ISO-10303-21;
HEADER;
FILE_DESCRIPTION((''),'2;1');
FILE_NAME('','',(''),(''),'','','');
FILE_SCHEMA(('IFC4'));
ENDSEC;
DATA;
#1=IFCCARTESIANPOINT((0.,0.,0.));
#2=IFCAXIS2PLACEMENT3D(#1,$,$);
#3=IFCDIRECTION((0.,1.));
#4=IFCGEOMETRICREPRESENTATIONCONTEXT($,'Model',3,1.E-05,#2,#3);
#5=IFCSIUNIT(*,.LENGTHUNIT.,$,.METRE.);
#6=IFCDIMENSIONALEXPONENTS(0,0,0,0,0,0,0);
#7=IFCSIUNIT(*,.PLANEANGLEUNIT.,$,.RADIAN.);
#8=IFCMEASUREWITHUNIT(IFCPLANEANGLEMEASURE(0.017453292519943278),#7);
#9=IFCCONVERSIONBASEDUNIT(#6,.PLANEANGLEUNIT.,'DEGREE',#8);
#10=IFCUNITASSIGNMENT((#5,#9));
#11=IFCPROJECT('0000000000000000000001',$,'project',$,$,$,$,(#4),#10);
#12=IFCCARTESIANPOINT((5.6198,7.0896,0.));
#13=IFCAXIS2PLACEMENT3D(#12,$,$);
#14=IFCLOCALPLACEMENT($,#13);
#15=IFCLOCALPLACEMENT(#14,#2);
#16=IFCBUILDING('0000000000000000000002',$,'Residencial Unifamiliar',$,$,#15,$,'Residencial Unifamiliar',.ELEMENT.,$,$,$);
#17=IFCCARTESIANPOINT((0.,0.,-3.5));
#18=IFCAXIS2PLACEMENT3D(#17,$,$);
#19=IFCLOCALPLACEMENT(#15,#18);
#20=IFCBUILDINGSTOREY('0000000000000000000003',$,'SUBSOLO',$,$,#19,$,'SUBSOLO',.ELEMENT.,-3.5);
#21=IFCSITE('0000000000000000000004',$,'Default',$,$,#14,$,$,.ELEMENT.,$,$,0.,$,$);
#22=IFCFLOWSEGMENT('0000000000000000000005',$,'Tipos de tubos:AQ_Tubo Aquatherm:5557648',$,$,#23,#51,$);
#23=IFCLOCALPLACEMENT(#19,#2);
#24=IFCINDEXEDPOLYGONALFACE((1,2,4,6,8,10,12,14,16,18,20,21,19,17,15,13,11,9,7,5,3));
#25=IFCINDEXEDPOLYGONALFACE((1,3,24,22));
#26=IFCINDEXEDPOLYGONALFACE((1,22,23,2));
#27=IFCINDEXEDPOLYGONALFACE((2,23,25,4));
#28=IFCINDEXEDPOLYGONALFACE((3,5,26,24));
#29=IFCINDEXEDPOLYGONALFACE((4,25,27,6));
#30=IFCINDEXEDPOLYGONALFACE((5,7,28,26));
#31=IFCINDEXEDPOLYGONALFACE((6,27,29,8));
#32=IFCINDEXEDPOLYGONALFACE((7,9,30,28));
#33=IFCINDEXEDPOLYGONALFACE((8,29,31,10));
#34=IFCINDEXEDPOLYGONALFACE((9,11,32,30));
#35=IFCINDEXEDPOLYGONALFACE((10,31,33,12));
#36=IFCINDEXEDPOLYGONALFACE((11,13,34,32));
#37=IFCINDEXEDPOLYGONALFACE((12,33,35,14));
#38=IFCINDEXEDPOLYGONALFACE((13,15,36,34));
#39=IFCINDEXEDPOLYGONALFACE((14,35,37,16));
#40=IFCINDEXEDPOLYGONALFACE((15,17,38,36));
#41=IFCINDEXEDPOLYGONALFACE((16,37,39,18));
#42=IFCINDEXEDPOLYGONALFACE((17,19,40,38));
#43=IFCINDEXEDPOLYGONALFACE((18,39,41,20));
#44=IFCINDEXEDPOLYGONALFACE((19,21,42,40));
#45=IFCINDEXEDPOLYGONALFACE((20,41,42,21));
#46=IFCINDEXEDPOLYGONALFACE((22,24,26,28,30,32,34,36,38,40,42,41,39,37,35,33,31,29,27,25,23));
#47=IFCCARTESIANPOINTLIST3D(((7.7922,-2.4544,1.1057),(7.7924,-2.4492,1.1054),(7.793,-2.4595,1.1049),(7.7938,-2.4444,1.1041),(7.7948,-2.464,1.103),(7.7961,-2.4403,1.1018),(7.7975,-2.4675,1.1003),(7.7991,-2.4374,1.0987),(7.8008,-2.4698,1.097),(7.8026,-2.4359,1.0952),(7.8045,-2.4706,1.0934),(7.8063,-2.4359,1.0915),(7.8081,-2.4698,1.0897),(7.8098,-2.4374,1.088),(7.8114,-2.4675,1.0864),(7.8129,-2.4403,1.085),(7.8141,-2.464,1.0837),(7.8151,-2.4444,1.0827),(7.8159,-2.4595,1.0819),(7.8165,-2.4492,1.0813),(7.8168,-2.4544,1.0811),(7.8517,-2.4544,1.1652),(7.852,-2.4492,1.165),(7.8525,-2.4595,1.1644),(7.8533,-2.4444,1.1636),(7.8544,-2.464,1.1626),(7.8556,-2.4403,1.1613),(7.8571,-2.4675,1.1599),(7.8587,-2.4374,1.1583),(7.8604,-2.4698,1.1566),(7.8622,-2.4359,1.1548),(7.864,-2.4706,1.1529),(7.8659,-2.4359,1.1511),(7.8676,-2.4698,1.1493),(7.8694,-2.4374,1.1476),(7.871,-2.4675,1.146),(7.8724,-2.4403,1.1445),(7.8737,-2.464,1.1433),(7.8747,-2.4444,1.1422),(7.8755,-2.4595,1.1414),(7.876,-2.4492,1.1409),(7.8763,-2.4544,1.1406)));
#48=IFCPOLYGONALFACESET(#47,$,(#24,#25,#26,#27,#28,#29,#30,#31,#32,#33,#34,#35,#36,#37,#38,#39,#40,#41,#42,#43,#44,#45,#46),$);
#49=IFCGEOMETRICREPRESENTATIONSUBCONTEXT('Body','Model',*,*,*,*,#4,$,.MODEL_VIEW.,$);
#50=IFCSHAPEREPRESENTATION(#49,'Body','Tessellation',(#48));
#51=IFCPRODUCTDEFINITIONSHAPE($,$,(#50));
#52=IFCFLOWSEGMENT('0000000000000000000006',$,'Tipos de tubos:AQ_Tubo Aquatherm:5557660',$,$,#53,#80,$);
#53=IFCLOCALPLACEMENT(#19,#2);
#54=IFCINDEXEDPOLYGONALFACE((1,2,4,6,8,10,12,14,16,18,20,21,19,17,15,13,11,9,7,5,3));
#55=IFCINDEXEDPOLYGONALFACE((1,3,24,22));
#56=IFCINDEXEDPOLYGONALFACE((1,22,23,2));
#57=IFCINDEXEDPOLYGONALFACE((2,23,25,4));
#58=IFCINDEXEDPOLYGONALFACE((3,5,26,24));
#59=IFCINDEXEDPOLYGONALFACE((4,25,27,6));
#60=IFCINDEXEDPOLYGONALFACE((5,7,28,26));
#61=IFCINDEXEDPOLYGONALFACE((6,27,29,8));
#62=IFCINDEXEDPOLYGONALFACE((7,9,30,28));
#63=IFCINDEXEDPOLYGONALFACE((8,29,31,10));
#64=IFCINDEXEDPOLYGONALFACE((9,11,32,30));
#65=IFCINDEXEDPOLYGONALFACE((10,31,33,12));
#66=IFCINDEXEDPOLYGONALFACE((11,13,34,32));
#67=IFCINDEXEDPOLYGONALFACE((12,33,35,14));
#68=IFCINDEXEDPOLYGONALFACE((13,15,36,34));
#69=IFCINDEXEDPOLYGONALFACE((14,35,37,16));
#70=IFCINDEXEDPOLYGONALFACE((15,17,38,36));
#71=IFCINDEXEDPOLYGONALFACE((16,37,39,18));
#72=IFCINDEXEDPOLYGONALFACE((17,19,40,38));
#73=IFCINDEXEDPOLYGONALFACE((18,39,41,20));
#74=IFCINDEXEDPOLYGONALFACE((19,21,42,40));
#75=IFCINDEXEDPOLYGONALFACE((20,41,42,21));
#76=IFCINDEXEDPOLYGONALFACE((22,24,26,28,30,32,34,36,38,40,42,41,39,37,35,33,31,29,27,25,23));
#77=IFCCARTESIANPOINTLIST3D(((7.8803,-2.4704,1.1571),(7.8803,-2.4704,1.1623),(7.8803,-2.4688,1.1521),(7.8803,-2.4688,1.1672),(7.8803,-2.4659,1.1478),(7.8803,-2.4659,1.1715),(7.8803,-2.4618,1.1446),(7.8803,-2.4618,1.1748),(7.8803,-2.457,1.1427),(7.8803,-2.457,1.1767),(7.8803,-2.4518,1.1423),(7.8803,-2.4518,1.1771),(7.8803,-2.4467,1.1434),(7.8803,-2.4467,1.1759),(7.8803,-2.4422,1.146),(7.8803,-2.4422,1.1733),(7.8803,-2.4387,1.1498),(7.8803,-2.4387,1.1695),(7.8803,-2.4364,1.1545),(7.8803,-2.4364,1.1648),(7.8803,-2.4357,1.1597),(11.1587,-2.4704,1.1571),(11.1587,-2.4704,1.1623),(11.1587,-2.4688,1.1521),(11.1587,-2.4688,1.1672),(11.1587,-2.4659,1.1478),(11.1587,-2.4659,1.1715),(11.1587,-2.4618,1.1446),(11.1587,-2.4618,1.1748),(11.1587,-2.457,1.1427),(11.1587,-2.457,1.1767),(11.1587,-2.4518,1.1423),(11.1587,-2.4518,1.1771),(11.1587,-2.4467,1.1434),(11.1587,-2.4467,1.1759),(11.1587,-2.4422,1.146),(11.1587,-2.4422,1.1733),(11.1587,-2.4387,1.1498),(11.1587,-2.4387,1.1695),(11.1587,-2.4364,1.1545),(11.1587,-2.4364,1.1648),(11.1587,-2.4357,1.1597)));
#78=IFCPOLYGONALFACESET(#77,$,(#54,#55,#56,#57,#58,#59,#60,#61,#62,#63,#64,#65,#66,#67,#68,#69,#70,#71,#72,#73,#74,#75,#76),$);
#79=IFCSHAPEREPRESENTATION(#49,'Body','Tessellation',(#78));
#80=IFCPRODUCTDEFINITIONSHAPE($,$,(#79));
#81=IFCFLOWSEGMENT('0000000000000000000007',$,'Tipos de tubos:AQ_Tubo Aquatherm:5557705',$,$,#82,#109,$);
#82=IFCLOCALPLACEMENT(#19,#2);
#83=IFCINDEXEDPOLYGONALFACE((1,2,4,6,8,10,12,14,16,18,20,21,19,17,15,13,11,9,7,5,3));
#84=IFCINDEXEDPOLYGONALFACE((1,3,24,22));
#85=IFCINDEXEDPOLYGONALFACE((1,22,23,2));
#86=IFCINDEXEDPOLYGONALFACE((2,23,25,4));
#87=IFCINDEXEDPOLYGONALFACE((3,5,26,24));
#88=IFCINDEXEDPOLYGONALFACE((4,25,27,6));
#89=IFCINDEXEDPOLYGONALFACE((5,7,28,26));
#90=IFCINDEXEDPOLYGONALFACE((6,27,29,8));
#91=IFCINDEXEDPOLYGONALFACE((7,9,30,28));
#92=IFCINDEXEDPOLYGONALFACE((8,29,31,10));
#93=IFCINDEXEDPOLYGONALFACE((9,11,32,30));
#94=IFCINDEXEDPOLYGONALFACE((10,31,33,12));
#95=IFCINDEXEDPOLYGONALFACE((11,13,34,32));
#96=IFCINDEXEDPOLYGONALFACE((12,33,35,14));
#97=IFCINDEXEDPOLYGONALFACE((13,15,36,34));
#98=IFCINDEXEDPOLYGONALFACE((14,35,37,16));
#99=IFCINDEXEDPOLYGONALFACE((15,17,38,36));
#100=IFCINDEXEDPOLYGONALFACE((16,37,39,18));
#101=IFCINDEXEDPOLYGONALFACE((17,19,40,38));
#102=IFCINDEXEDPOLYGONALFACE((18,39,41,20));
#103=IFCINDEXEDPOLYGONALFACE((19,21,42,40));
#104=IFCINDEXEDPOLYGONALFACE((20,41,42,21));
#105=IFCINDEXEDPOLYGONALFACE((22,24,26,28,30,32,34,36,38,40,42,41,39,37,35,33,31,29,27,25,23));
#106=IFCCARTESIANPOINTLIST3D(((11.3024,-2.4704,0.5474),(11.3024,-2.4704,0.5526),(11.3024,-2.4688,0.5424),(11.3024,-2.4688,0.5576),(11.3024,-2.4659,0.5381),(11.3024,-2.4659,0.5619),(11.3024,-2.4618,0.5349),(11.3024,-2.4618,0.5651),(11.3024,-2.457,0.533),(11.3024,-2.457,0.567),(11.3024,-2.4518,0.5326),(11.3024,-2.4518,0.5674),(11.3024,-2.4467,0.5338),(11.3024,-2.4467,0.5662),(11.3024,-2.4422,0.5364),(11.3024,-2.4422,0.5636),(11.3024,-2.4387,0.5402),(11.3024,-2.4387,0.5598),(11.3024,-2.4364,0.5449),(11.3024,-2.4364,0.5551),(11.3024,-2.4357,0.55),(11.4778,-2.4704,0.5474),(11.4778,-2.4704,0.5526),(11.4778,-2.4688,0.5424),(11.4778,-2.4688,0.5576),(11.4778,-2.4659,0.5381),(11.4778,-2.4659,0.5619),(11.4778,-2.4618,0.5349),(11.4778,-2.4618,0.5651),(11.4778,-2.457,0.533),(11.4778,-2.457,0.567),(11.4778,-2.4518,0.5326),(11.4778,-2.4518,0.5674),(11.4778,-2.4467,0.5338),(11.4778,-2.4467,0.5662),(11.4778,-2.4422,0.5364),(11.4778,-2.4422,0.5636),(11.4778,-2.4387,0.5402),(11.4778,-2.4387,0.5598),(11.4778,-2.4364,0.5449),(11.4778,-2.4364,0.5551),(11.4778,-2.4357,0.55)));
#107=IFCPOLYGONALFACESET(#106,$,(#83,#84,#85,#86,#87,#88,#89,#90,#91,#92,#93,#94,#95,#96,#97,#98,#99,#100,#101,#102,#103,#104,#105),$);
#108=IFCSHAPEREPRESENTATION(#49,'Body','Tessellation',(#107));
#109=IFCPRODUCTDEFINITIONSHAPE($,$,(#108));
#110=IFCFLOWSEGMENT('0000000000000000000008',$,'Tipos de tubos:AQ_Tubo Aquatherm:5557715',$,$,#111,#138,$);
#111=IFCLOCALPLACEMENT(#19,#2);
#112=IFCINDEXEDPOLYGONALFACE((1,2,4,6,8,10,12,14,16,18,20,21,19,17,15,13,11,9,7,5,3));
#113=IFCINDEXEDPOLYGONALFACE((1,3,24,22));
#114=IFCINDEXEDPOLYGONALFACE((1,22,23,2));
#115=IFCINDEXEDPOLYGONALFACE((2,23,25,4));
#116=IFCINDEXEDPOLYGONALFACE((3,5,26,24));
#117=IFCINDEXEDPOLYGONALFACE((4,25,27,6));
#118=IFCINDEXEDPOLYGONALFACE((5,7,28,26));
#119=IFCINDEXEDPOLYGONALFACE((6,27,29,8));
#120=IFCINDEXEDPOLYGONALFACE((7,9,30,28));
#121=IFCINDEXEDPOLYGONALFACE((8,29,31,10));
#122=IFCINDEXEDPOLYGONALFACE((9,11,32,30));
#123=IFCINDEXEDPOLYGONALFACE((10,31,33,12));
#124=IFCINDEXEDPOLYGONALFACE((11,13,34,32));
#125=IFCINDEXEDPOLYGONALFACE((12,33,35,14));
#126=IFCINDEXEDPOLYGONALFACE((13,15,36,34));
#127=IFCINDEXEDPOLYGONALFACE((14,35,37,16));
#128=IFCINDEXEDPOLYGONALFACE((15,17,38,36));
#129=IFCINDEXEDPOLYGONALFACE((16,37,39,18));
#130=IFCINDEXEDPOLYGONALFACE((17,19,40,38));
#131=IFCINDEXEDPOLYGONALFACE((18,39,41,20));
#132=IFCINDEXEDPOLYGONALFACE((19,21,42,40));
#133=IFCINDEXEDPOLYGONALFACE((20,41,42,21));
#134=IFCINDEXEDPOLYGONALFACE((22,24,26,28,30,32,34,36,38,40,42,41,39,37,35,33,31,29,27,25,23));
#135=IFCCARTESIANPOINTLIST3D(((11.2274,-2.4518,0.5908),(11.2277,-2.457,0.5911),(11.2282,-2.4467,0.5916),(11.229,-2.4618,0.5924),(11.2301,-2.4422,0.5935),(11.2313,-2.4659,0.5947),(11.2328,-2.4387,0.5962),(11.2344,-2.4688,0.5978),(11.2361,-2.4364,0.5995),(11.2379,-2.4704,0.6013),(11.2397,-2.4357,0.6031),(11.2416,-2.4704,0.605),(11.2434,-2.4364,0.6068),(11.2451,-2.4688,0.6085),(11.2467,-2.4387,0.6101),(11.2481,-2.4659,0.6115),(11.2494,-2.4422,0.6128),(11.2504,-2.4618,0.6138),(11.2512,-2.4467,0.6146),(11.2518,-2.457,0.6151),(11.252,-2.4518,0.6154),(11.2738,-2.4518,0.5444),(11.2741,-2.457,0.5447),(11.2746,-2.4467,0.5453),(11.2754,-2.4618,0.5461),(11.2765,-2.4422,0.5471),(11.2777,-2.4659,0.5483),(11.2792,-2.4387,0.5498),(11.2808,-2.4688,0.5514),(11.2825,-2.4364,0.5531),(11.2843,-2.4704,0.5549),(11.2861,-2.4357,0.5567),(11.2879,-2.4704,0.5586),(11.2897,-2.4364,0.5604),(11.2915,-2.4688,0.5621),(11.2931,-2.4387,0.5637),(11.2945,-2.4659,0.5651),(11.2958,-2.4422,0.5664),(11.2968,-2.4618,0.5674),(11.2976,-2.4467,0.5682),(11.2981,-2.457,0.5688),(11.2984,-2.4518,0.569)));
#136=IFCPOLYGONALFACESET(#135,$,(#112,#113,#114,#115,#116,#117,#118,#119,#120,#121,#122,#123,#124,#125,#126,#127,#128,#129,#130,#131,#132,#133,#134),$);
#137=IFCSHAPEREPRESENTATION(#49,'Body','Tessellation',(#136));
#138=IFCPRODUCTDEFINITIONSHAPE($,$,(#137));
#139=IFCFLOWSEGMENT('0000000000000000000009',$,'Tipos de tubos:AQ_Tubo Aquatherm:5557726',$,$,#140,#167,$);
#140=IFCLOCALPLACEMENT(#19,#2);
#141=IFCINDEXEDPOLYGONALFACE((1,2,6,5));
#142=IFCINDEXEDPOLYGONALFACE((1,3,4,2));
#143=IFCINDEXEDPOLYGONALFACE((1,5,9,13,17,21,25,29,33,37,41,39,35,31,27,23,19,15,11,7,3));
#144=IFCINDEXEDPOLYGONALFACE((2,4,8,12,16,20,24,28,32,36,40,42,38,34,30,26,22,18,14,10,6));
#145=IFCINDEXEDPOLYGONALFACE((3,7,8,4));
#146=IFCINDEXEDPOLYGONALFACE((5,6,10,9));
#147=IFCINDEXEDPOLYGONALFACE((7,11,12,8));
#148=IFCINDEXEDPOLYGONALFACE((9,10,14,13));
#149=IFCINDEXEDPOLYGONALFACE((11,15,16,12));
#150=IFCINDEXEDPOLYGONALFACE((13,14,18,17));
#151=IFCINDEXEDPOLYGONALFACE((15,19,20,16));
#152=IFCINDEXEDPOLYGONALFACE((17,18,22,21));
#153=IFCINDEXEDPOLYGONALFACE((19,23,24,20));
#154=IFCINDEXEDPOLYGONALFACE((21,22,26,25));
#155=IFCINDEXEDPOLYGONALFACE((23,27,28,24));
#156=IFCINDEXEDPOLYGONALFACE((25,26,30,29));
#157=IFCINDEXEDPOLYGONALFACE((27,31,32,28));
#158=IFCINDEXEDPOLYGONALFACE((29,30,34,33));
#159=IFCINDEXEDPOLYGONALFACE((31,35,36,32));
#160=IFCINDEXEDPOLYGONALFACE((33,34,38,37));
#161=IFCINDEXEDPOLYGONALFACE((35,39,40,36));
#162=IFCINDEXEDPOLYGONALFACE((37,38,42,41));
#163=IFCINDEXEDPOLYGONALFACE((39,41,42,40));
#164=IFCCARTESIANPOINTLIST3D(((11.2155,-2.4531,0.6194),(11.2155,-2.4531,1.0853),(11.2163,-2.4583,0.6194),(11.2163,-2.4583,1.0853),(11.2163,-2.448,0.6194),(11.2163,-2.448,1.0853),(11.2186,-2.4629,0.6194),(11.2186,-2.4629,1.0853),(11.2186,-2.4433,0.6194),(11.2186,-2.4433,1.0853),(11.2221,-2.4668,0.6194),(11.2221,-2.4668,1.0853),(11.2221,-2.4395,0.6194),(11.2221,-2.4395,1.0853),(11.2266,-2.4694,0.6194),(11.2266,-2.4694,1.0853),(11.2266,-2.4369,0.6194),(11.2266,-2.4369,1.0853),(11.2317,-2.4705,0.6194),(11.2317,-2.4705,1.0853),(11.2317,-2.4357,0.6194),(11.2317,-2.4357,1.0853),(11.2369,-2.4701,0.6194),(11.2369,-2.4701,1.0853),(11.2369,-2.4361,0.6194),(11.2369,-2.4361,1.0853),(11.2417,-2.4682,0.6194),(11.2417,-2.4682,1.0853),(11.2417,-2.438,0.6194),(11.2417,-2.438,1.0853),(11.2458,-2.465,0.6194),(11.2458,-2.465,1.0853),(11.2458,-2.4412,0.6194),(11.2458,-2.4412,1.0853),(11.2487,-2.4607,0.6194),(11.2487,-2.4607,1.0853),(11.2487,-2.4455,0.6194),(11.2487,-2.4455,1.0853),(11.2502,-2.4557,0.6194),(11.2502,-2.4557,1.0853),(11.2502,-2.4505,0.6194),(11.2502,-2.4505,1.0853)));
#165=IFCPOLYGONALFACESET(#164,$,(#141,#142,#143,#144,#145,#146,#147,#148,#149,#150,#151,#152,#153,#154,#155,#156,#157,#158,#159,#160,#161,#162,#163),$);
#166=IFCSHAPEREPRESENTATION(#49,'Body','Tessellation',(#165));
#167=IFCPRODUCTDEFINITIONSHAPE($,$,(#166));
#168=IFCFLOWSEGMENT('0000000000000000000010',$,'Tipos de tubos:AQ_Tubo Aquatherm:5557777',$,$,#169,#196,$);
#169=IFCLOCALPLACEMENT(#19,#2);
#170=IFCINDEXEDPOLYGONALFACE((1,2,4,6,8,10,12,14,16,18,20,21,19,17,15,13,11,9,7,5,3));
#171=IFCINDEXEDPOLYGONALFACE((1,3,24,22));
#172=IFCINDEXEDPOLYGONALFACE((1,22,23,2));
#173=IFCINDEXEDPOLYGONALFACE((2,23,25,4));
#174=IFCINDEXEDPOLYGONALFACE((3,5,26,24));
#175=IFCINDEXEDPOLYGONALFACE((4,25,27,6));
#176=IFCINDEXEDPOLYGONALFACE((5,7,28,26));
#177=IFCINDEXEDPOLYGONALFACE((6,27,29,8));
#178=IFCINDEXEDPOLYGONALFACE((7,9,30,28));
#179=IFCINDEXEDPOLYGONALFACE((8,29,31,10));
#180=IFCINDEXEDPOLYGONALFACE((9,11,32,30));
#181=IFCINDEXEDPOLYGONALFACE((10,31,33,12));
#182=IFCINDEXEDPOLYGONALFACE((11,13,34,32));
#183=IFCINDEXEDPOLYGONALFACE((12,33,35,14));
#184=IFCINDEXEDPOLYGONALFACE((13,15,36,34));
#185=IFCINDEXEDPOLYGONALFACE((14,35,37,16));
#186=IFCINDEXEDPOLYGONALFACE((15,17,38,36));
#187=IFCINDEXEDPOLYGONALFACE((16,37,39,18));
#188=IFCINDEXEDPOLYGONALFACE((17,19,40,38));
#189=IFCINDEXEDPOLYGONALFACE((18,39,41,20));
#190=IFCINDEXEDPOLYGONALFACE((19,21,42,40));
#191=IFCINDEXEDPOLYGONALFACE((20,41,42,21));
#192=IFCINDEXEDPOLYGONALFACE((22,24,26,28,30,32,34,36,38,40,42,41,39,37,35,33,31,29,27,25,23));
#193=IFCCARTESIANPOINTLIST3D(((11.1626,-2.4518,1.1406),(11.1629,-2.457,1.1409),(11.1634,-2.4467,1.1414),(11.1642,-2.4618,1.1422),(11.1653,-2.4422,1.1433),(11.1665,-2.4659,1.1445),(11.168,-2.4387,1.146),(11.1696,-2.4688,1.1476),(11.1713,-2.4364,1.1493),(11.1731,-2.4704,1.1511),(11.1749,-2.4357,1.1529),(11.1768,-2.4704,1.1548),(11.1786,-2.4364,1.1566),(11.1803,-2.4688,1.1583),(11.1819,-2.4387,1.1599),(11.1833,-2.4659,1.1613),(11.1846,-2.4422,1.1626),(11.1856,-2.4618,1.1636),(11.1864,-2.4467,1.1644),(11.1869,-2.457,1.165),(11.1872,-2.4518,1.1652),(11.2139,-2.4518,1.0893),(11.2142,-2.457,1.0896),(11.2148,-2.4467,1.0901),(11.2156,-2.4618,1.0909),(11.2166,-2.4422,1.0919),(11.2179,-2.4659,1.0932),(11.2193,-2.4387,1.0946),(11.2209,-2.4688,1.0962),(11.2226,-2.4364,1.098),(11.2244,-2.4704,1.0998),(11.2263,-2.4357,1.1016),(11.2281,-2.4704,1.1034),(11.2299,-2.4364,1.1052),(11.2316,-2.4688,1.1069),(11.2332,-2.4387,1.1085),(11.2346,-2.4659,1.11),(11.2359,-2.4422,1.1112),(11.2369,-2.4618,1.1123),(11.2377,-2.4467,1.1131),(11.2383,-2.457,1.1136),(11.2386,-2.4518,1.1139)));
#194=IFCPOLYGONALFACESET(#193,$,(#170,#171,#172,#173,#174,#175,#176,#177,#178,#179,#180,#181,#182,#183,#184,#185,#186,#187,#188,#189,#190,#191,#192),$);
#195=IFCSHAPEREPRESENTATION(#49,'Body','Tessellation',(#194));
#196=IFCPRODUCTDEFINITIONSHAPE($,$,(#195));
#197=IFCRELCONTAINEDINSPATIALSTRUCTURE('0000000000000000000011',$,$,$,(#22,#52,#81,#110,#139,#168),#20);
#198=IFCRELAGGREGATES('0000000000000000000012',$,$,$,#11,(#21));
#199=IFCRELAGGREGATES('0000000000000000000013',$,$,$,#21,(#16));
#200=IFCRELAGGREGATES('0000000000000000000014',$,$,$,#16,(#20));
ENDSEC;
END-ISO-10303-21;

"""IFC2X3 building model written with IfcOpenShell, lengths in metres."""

from ifc_helpers import new_model, entity, si_unit, converted_unit, direction, frame, frame_2d, origin, origin_2d_with_axis, place, context, subcontext, project, spatial, circle, extrude, element, save


model = new_model("IFC2X3")

# Units and contexts
model_context = context("Model", 3, precision=1e-05, world=origin(), true_north=direction((0.0, 1.0)))
body_context = subcontext(model_context, "Body", "Model", "MODEL_VIEW")
ifc_project = project(units=[si_unit("LENGTHUNIT", "METRE"), converted_unit("PLANEANGLEUNIT", "DEGREE", entity("IfcPlaneAngleMeasure", 0.017453292519943278), si_unit("PLANEANGLEUNIT", "RADIAN"), dimensions=[0, 0, 0, 0, 0, 0, 0])], contexts=[model_context])

# Site, building, storey
site_placement = place(None, frame((5.6198, 7.0896, 0.0)))
site = spatial("IfcSite", under=ifc_project, at=site_placement, Name="Default", CompositionType="ELEMENT", RefElevation=0.0)
building_placement = place(site_placement, origin())
building = spatial("IfcBuilding", under=site, at=building_placement, Name="Residencial Unifamiliar", LongName="Residencial Unifamiliar", CompositionType="ELEMENT")
storey_placement = place(building_placement, frame((0.0, 0.0, -3.5)))
storey = spatial("IfcBuildingStorey", under=building, at=storey_placement, Name="SUBSOLO", LongName="SUBSOLO", CompositionType="ELEMENT", Elevation=-3.5)

# Flow segments
flow_segment_1_placement = place(storey_placement, origin())
element("IfcFlowSegment", 1, at=flow_segment_1_placement, inside=storey, Name="Tipos de tubos:AQ_Tubo Aquatherm:5557648", context=body_context, shape_type="SweptSolid", body=[
    extrude(circle(Radius=0.0175, at=frame_2d((0.0, 0.0), x_axis=(1.0, 0.0))), frame((7.8045, -2.4531, 1.0934), z_axis=(0.707107, 0.0, 0.707107), x_axis=(0.0, -1.0, 0.0)), (0.0, 0.0, 1.0), 0.0842),
])
flow_segment_2_placement = place(storey_placement, origin())
element("IfcFlowSegment", 2, at=flow_segment_2_placement, inside=storey, Name="Tipos de tubos:AQ_Tubo Aquatherm:5557660", context=body_context, shape_type="SweptSolid", body=[
    extrude(circle(Radius=0.0175, at=frame_2d((0.0, 0.0), x_axis=(1.0, 0.0))), frame((7.8803, -2.4531, 1.1597), z_axis=(1.0, 0.0, 0.0), x_axis=(0.0, 1.0, 0.0)), (0.0, 0.0, 1.0), 3.2784),
])
flow_segment_3_placement = place(storey_placement, origin())
element("IfcFlowSegment", 3, at=flow_segment_3_placement, inside=storey, Name="Tipos de tubos:AQ_Tubo Aquatherm:5557705", context=body_context, shape_type="SweptSolid", body=[
    extrude(circle(Radius=0.0175, at=frame_2d((0.0, 0.0), x_axis=(1.0, 0.0))), frame((11.3024, -2.4531, 0.55), z_axis=(1.0, 0.0, 0.0), x_axis=(0.0, 1.0, 0.0)), (0.0, 0.0, 1.0), 0.1755),
])
flow_segment_4_placement = place(storey_placement, origin())
element("IfcFlowSegment", 4, at=flow_segment_4_placement, inside=storey, Name="Tipos de tubos:AQ_Tubo Aquatherm:5557715", context=body_context, shape_type="SweptSolid", body=[
    extrude(circle(Radius=0.0175, at=frame_2d((0.0, 0.0), x_axis=(1.0, 0.0))), frame((11.2861, -2.4531, 0.5567), z_axis=(-0.707107, 0.0, 0.707107), x_axis=(0.0, 1.0, 0.0)), (0.0, 0.0, 1.0), 0.0656),
])
flow_segment_5_placement = place(storey_placement, origin())
element("IfcFlowSegment", 5, at=flow_segment_5_placement, inside=storey, Name="Tipos de tubos:AQ_Tubo Aquatherm:5557726", context=body_context, shape_type="SweptSolid", body=[
    extrude(circle(Radius=0.0175, at=origin_2d_with_axis()), frame((11.233, -2.4531, 0.6194), z_axis=(0.0, 0.0, 1.0), x_axis=(-1.0, 0.0, 0.0)), (0.0, 0.0, 1.0), 0.4659),
])
flow_segment_6_placement = place(storey_placement, origin())
element("IfcFlowSegment", 6, at=flow_segment_6_placement, inside=storey, Name="Tipos de tubos:AQ_Tubo Aquatherm:5557777", context=body_context, shape_type="SweptSolid", body=[
    extrude(circle(Radius=0.0175, at=frame_2d((0.0, 0.0), x_axis=(1.0, 0.0))), frame((11.2263, -2.4531, 1.1016), z_axis=(-0.707107, 0.0, 0.707107), x_axis=(0.0, 1.0, 0.0)), (0.0, 0.0, 1.0), 0.0726),
])

save(model, "model.ifc")
